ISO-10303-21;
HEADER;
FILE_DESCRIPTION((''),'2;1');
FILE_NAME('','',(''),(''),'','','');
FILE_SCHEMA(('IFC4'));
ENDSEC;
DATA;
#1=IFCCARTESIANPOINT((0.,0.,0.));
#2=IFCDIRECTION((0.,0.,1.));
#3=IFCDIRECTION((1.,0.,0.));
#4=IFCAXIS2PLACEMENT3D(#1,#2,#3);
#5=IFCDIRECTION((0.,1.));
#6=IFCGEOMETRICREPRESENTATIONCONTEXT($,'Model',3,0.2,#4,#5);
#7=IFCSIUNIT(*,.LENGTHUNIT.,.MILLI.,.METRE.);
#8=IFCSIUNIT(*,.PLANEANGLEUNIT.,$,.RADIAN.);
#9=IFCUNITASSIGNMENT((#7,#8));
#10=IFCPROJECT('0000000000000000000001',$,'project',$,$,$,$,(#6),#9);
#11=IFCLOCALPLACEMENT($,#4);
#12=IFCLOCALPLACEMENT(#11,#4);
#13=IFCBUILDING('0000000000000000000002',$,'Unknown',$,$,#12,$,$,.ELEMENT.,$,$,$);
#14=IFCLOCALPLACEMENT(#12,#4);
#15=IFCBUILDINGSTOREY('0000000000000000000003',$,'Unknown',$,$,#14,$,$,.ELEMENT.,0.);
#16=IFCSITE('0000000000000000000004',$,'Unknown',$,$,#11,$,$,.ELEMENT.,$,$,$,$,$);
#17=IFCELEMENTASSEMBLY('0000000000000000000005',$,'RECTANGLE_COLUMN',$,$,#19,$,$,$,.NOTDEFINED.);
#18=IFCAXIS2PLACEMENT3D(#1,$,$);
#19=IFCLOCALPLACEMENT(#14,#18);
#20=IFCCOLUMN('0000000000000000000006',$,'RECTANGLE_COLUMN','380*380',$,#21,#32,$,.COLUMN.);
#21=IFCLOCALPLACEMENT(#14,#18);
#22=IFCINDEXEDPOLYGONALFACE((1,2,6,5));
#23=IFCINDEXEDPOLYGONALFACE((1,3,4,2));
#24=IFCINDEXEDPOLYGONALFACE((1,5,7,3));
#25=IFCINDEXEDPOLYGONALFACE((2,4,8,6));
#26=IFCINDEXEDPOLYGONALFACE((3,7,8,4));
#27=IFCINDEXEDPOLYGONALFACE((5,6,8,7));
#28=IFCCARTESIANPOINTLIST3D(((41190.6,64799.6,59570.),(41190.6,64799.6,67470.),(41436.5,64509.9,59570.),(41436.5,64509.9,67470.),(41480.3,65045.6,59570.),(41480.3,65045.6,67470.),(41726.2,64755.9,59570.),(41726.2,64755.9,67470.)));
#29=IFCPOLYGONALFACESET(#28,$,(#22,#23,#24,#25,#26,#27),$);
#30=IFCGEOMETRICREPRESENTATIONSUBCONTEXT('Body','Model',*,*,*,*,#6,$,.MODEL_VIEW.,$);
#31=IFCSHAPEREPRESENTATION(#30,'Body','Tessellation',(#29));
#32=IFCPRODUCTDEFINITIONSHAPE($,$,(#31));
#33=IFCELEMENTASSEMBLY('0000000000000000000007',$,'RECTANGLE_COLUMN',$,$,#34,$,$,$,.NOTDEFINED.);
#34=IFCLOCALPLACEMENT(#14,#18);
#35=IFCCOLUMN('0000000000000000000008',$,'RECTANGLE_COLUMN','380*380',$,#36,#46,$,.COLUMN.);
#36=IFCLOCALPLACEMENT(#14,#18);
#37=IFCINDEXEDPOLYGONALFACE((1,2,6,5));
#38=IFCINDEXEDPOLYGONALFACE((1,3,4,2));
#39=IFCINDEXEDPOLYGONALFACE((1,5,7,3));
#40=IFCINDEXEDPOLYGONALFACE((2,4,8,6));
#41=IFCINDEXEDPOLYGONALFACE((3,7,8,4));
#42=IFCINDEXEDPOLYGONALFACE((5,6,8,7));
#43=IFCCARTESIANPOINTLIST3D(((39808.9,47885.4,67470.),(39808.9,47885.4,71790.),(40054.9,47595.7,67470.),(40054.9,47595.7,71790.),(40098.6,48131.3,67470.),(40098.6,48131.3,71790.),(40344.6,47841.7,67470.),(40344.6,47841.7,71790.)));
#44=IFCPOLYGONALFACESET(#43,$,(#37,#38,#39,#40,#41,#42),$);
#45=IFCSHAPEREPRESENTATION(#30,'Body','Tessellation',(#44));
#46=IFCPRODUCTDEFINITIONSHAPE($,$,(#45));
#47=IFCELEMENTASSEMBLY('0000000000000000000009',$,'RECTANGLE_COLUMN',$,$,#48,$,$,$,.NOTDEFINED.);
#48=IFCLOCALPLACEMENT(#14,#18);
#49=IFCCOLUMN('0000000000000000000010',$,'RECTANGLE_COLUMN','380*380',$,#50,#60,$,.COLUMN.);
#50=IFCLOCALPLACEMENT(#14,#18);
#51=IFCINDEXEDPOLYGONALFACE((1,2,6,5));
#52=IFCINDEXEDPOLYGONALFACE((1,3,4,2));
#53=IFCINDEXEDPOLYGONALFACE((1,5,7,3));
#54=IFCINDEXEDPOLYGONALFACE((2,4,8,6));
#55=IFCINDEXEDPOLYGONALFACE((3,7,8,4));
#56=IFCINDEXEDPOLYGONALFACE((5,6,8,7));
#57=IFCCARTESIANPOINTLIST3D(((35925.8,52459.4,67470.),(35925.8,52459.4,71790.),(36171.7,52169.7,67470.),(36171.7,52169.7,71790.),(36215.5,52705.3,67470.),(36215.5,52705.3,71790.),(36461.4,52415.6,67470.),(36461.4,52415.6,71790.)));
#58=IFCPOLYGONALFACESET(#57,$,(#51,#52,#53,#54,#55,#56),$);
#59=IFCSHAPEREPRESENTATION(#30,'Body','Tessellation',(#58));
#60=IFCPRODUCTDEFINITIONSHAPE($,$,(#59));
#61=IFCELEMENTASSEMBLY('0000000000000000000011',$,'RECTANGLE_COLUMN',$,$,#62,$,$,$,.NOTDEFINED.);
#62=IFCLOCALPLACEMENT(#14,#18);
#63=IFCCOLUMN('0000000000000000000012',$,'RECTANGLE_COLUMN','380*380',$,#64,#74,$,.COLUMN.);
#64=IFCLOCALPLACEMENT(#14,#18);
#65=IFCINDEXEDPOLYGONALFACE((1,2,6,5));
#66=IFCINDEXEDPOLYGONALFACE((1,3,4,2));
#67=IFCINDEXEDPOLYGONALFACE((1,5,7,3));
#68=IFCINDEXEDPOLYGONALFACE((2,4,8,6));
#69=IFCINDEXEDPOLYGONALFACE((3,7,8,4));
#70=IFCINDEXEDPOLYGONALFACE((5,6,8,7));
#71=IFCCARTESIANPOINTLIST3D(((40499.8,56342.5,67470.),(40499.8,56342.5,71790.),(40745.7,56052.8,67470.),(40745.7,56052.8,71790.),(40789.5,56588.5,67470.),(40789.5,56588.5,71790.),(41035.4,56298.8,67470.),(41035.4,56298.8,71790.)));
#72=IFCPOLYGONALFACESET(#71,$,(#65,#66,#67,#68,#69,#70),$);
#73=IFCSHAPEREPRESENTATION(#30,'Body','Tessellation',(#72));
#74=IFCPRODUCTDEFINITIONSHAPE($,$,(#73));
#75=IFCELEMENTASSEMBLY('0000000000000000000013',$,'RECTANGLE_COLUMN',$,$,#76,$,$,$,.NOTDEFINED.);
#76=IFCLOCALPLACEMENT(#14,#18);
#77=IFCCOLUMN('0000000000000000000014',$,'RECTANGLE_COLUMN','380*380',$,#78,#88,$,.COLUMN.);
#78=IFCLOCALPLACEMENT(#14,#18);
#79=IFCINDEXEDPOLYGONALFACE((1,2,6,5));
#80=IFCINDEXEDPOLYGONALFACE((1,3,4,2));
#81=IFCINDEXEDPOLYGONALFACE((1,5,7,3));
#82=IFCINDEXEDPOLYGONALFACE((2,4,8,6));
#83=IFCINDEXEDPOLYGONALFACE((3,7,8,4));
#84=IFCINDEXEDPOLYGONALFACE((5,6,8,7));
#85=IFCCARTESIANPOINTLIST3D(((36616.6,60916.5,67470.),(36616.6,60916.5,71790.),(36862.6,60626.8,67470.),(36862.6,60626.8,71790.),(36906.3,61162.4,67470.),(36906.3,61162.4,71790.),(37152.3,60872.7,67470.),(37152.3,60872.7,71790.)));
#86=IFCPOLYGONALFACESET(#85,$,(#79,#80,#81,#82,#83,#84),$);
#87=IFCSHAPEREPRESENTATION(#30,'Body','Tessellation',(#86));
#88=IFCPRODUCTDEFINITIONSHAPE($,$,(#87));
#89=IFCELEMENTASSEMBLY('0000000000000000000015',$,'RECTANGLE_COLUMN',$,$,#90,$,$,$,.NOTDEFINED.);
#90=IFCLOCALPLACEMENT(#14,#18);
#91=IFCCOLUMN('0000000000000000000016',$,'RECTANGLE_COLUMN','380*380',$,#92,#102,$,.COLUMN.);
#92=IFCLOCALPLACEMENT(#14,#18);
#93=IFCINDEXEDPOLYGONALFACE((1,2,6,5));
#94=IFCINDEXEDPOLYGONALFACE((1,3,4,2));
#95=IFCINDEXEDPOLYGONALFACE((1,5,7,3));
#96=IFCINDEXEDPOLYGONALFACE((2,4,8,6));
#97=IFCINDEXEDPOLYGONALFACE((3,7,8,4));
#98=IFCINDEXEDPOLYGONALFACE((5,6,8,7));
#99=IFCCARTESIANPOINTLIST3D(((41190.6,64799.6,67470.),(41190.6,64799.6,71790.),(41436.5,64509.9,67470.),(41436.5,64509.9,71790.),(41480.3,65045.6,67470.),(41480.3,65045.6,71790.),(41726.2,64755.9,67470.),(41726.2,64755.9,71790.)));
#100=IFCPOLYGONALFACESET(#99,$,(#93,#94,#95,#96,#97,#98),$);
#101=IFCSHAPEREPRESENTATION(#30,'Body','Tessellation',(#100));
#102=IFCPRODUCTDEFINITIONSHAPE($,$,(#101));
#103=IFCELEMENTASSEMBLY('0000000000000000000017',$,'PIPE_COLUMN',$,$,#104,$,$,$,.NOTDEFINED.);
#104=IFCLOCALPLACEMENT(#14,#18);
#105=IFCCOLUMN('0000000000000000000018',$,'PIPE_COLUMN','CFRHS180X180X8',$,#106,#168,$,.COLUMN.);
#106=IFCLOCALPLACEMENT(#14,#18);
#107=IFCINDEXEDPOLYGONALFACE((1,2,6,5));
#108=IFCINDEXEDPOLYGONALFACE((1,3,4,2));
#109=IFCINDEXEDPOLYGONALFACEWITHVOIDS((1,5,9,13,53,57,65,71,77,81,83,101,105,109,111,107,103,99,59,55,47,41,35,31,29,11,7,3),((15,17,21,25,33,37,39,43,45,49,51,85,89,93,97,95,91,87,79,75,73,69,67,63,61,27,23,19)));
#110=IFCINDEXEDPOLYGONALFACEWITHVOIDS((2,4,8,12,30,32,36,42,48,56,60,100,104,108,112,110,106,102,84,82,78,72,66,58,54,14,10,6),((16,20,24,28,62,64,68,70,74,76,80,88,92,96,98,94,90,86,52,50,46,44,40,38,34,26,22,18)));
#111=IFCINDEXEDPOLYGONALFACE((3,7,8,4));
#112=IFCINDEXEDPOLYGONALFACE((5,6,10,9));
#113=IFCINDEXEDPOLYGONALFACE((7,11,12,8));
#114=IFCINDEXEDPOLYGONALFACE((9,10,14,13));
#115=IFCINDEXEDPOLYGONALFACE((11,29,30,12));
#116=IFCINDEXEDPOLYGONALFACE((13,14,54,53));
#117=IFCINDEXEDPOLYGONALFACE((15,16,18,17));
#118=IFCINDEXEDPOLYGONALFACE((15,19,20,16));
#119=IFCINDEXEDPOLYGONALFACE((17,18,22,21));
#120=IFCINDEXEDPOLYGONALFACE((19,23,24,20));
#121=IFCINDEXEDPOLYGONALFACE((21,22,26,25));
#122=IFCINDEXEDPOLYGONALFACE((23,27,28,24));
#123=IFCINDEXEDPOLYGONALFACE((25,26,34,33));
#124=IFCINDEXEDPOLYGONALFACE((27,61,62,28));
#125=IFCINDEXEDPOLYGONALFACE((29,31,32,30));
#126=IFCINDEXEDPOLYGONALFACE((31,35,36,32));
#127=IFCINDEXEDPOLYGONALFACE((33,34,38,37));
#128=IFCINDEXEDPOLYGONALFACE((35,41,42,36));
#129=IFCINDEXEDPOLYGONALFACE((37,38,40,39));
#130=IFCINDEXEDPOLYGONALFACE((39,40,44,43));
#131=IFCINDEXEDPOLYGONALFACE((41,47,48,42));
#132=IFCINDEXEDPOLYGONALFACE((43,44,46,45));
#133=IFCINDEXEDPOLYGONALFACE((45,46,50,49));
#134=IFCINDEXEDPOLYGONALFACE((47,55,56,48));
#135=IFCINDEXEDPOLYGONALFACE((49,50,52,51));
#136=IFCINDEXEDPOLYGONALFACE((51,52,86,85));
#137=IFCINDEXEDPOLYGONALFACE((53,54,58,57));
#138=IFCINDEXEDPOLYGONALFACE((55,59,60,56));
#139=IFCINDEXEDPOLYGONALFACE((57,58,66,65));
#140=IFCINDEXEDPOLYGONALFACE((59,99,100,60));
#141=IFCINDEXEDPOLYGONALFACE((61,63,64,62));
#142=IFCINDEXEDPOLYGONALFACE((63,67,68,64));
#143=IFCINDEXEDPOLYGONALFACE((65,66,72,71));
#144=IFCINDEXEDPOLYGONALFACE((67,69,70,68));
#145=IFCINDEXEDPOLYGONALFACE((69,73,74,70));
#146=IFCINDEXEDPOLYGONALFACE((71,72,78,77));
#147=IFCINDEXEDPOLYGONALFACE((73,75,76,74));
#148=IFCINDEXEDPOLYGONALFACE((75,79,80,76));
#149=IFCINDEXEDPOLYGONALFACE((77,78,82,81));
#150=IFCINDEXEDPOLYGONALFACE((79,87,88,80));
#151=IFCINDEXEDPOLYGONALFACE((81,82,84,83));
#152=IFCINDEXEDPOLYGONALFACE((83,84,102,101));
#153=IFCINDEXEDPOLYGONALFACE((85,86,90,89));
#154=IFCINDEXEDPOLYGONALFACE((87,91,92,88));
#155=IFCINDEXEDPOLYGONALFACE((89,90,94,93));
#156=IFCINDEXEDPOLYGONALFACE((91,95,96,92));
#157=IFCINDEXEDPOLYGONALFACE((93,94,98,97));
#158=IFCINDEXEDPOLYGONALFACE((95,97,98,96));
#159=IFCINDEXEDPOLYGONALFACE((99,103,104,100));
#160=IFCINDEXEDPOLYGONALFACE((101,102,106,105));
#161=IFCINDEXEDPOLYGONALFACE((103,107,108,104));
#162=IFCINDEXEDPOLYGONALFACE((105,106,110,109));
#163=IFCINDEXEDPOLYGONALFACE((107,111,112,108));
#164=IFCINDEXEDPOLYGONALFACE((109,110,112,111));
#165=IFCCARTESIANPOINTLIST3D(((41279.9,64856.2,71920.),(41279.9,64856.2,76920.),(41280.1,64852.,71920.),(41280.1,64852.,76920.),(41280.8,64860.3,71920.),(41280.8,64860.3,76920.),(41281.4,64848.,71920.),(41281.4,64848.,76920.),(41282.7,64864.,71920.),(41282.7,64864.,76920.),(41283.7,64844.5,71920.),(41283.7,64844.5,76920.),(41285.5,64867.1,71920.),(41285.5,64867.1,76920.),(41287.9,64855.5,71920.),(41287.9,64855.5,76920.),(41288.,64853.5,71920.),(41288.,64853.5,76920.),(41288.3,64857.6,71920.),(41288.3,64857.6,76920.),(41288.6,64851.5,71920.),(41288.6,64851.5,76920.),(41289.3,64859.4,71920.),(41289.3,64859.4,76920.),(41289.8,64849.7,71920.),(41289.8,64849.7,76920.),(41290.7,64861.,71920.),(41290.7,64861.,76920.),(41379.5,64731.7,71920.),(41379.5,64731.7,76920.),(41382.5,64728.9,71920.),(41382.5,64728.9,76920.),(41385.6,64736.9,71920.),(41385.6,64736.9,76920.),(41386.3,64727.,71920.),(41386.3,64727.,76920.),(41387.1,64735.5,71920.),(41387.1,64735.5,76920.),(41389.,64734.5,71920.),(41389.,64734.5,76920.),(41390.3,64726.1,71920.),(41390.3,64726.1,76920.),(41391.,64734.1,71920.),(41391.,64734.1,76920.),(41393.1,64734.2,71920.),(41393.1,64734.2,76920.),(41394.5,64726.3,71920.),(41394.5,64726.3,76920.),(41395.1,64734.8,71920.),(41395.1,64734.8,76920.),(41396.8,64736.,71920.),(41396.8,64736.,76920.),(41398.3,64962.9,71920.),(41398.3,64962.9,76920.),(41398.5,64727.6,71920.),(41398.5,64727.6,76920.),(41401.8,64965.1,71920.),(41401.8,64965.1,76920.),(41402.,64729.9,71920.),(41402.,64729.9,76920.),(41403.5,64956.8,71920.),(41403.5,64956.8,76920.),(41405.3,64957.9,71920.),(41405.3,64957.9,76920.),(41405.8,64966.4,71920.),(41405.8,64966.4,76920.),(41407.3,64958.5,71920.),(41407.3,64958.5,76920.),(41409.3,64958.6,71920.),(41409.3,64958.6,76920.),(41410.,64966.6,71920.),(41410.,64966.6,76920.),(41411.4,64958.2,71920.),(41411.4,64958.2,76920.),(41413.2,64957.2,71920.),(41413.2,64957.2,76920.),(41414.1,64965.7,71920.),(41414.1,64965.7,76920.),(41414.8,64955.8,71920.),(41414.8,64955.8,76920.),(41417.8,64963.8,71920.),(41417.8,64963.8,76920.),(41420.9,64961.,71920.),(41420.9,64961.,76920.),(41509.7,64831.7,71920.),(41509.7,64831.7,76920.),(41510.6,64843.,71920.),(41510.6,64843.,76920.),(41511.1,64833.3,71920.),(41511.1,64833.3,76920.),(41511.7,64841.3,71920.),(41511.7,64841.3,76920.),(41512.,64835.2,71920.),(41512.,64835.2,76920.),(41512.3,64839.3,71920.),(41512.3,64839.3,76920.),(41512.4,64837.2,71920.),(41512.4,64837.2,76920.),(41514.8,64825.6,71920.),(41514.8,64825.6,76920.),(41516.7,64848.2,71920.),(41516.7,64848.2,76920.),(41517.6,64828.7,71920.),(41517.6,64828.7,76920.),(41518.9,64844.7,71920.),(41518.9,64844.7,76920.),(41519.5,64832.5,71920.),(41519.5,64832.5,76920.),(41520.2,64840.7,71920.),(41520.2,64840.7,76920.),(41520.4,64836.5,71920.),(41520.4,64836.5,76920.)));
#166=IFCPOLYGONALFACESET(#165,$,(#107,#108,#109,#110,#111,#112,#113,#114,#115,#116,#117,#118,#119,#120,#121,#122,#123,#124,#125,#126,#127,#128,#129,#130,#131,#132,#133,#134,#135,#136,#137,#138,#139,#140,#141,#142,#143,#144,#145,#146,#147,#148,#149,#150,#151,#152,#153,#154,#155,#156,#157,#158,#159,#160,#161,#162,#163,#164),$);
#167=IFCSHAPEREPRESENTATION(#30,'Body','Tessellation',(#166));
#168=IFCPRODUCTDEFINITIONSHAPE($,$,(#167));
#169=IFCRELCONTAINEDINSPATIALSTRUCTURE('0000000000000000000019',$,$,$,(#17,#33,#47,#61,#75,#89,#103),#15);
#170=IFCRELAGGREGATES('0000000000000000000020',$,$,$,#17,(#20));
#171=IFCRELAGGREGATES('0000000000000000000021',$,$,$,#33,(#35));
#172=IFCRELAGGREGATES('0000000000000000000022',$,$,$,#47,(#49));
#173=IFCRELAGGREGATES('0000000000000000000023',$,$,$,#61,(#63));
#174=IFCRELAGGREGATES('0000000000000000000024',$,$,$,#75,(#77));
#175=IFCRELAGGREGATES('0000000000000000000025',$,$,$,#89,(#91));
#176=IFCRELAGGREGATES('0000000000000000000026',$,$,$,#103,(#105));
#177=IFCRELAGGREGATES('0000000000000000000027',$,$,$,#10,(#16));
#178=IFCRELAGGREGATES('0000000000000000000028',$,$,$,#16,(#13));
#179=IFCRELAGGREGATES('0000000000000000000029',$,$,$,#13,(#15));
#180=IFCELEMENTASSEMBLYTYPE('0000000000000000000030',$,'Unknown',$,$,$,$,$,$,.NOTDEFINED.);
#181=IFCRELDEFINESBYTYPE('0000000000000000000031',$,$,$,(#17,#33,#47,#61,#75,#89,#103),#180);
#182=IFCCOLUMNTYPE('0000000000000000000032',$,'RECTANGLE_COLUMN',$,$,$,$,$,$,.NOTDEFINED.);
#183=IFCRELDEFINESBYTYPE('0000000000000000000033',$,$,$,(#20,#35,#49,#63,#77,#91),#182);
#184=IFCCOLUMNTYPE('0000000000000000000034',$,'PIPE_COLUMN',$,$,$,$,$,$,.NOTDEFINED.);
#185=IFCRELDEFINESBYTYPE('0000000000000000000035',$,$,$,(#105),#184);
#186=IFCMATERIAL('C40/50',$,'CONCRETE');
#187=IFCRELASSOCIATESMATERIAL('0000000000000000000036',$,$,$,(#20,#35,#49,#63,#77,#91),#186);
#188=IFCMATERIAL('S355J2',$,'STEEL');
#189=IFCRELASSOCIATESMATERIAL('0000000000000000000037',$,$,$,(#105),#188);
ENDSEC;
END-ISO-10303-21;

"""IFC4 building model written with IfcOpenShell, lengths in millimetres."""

from ifc_helpers import new_model, si_unit, direction, frame, origin_with_axes, origin_2d_with_axis, place, context, subcontext, project, spatial, rectangle, hollow_rectangle, extrude, material, material_profile, profile_set, profile_usage, type_object, element, aggregate, save


model = new_model("IFC4")

# Units and contexts
model_context = context("Model", 3, precision=0.2, world=origin_with_axes(), true_north=direction((0.0, 1.0)))
body_context = subcontext(model_context, "Body", "Model", "MODEL_VIEW")
ifc_project = project(units=[si_unit("LENGTHUNIT", "METRE", prefix="MILLI"), si_unit("PLANEANGLEUNIT", "RADIAN")], contexts=[model_context])

# Site, building, storey
site_placement = place(None, origin_with_axes())
site = spatial("IfcSite", under=ifc_project, at=site_placement, Name="Unknown", CompositionType="ELEMENT")
building_placement = place(site_placement, origin_with_axes())
building = spatial("IfcBuilding", under=site, at=building_placement, Name="Unknown", CompositionType="ELEMENT")
storey_placement = place(building_placement, origin_with_axes())
storey = spatial("IfcBuildingStorey", under=building, at=storey_placement, Name="Unknown", CompositionType="ELEMENT", Elevation=0.0)

# Element assemblies, columns
element_assembly_type = type_object("IfcElementAssemblyType", Name="Unknown", PredefinedType="NOTDEFINED")
assembly_1_placement = place(storey_placement, frame((41458.4, 64777.8, 59570.0), z_axis=(-0.762329, -0.64719, 0.0), x_axis=(0.0, 0.0, 1.0)))
assembly_1 = element("IfcElementAssembly", 1, at=assembly_1_placement, inside=storey, type_object=element_assembly_type, Name="RECTANGLE_COLUMN", PredefinedType="NOTDEFINED")
ifc_material_1 = material(Name="C40/50", Category="CONCRETE")
ifc_material_profile_1 = material_profile(ifc_material_1, rectangle(XDim=380.0, YDim=380.0, at=origin_2d_with_axis()), Name="380*380")
ifc_profile_set_1 = profile_set([ifc_material_profile_1])
ifc_profile_usage_1 = profile_usage(ifc_profile_set_1, cardinal=5)
column_type_1 = type_object("IfcColumnType", Name="RECTANGLE_COLUMN")
column_1_placement = place(assembly_1_placement, origin_with_axes())
column_1 = element("IfcColumn", 2, at=column_1_placement, type_object=column_type_1, material=ifc_profile_usage_1, Name="RECTANGLE_COLUMN", Description="380*380", PredefinedType="COLUMN", context=body_context, shape_type="SolidModel", body=[
    extrude(rectangle(XDim=380.0, YDim=380.0, at=origin_2d_with_axis()), frame((0.0, 0.0, 0.0), z_axis=(-1.0, 0.0, 0.0), x_axis=(0.0, 0.0, 1.0)), (0.0, 0.0, -1.0), 7900.0),
])
aggregate(assembly_1, [column_1])
assembly_2_placement = place(storey_placement, frame((40076.8, 47863.5, 67470.0), z_axis=(-0.762329, -0.64719, 0.0), x_axis=(0.0, 0.0, 1.0)))
assembly_2 = element("IfcElementAssembly", 3, at=assembly_2_placement, inside=storey, type_object=element_assembly_type, Name="RECTANGLE_COLUMN", PredefinedType="NOTDEFINED")
column_2_placement = place(assembly_2_placement, origin_with_axes())
column_2 = element("IfcColumn", 4, at=column_2_placement, type_object=column_type_1, material=ifc_profile_usage_1, Name="RECTANGLE_COLUMN", Description="380*380", PredefinedType="COLUMN", context=body_context, shape_type="SolidModel", body=[
    extrude(rectangle(XDim=380.0, YDim=380.0, at=origin_2d_with_axis()), frame((0.0, 0.0, 0.0), z_axis=(-1.0, 0.0, 0.0), x_axis=(0.0, 0.0, 1.0)), (0.0, 0.0, -1.0), 4320.0),
])
aggregate(assembly_2, [column_2])
assembly_3_placement = place(storey_placement, frame((36193.6, 52437.5, 67470.0), z_axis=(-0.762329, -0.64719, 0.0), x_axis=(0.0, 0.0, 1.0)))
assembly_3 = element("IfcElementAssembly", 5, at=assembly_3_placement, inside=storey, type_object=element_assembly_type, Name="RECTANGLE_COLUMN", PredefinedType="NOTDEFINED")
column_3_placement = place(assembly_3_placement, origin_with_axes())
column_3 = element("IfcColumn", 6, at=column_3_placement, type_object=column_type_1, material=ifc_profile_usage_1, Name="RECTANGLE_COLUMN", Description="380*380", PredefinedType="COLUMN", context=body_context, shape_type="SolidModel", body=[
    extrude(rectangle(XDim=380.0, YDim=380.0, at=origin_2d_with_axis()), frame((0.0, 0.0, 0.0), z_axis=(-1.0, 0.0, 0.0), x_axis=(0.0, 0.0, 1.0)), (0.0, 0.0, -1.0), 4320.0),
])
aggregate(assembly_3, [column_3])
assembly_4_placement = place(storey_placement, frame((40767.6, 56320.6, 67470.0), z_axis=(-0.762329, -0.64719, 0.0), x_axis=(0.0, 0.0, 1.0)))
assembly_4 = element("IfcElementAssembly", 7, at=assembly_4_placement, inside=storey, type_object=element_assembly_type, Name="RECTANGLE_COLUMN", PredefinedType="NOTDEFINED")
column_4_placement = place(assembly_4_placement, origin_with_axes())
column_4 = element("IfcColumn", 8, at=column_4_placement, type_object=column_type_1, material=ifc_profile_usage_1, Name="RECTANGLE_COLUMN", Description="380*380", PredefinedType="COLUMN", context=body_context, shape_type="SolidModel", body=[
    extrude(rectangle(XDim=380.0, YDim=380.0, at=origin_2d_with_axis()), frame((0.0, 0.0, 0.0), z_axis=(-1.0, 0.0, 0.0), x_axis=(0.0, 0.0, 1.0)), (0.0, 0.0, -1.0), 4320.0),
])
aggregate(assembly_4, [column_4])
assembly_5_placement = place(storey_placement, frame((36884.4, 60894.6, 67470.0), z_axis=(-0.762329, -0.64719, 0.0), x_axis=(0.0, 0.0, 1.0)))
assembly_5 = element("IfcElementAssembly", 9, at=assembly_5_placement, inside=storey, type_object=element_assembly_type, Name="RECTANGLE_COLUMN", PredefinedType="NOTDEFINED")
column_5_placement = place(assembly_5_placement, origin_with_axes())
column_5 = element("IfcColumn", 10, at=column_5_placement, type_object=column_type_1, material=ifc_profile_usage_1, Name="RECTANGLE_COLUMN", Description="380*380", PredefinedType="COLUMN", context=body_context, shape_type="SolidModel", body=[
    extrude(rectangle(XDim=380.0, YDim=380.0, at=origin_2d_with_axis()), frame((0.0, 0.0, 0.0), z_axis=(-1.0, 0.0, 0.0), x_axis=(0.0, 0.0, 1.0)), (0.0, 0.0, -1.0), 4320.0),
])
aggregate(assembly_5, [column_5])
assembly_6_placement = place(storey_placement, frame((41458.4, 64777.8, 67470.0), z_axis=(-0.762329, -0.64719, 0.0), x_axis=(0.0, 0.0, 1.0)))
assembly_6 = element("IfcElementAssembly", 11, at=assembly_6_placement, inside=storey, type_object=element_assembly_type, Name="RECTANGLE_COLUMN", PredefinedType="NOTDEFINED")
column_6_placement = place(assembly_6_placement, origin_with_axes())
column_6 = element("IfcColumn", 12, at=column_6_placement, type_object=column_type_1, material=ifc_profile_usage_1, Name="RECTANGLE_COLUMN", Description="380*380", PredefinedType="COLUMN", context=body_context, shape_type="SolidModel", body=[
    extrude(rectangle(XDim=380.0, YDim=380.0, at=origin_2d_with_axis()), frame((0.0, 0.0, 0.0), z_axis=(-1.0, 0.0, 0.0), x_axis=(0.0, 0.0, 1.0)), (0.0, 0.0, -1.0), 4320.0),
])
aggregate(assembly_6, [column_6])
assembly_7_placement = place(storey_placement, frame((41400.2, 64846.4, 71920.0), z_axis=(-0.762329, -0.64719, 0.0), x_axis=(0.0, 0.0, 1.0)))
assembly_7 = element("IfcElementAssembly", 13, at=assembly_7_placement, inside=storey, type_object=element_assembly_type, Name="PIPE_COLUMN", PredefinedType="NOTDEFINED")
ifc_material_2 = material(Name="S355J2", Category="STEEL")
ifc_material_profile_2 = material_profile(ifc_material_2, hollow_rectangle(XDim=180.0, YDim=180.0, WallThickness=8.0, InnerFilletRadius=8.0, OuterFilletRadius=16.0, at=origin_2d_with_axis()), Name="CFRHS180X180X8")
ifc_profile_set_2 = profile_set([ifc_material_profile_2])
ifc_profile_usage_2 = profile_usage(ifc_profile_set_2, cardinal=6)
column_type_2 = type_object("IfcColumnType", Name="PIPE_COLUMN")
column_7_placement = place(assembly_7_placement, origin_with_axes())
column_7 = element("IfcColumn", 14, at=column_7_placement, type_object=column_type_2, material=ifc_profile_usage_2, Name="PIPE_COLUMN", Description="CFRHS180X180X8", PredefinedType="COLUMN", context=body_context, shape_type="SolidModel", body=[
    extrude(hollow_rectangle(XDim=180.0, YDim=180.0, WallThickness=8.0, InnerFilletRadius=8.0, OuterFilletRadius=16.0, at=origin_2d_with_axis()), frame((0.0, 0.0, 0.0), z_axis=(-1.0, 0.0, 0.0), x_axis=(0.0, 0.0, 1.0)), (0.0, 0.0, -1.0), 5000.0),
])
aggregate(assembly_7, [column_7])

save(model, "model.ifc")
